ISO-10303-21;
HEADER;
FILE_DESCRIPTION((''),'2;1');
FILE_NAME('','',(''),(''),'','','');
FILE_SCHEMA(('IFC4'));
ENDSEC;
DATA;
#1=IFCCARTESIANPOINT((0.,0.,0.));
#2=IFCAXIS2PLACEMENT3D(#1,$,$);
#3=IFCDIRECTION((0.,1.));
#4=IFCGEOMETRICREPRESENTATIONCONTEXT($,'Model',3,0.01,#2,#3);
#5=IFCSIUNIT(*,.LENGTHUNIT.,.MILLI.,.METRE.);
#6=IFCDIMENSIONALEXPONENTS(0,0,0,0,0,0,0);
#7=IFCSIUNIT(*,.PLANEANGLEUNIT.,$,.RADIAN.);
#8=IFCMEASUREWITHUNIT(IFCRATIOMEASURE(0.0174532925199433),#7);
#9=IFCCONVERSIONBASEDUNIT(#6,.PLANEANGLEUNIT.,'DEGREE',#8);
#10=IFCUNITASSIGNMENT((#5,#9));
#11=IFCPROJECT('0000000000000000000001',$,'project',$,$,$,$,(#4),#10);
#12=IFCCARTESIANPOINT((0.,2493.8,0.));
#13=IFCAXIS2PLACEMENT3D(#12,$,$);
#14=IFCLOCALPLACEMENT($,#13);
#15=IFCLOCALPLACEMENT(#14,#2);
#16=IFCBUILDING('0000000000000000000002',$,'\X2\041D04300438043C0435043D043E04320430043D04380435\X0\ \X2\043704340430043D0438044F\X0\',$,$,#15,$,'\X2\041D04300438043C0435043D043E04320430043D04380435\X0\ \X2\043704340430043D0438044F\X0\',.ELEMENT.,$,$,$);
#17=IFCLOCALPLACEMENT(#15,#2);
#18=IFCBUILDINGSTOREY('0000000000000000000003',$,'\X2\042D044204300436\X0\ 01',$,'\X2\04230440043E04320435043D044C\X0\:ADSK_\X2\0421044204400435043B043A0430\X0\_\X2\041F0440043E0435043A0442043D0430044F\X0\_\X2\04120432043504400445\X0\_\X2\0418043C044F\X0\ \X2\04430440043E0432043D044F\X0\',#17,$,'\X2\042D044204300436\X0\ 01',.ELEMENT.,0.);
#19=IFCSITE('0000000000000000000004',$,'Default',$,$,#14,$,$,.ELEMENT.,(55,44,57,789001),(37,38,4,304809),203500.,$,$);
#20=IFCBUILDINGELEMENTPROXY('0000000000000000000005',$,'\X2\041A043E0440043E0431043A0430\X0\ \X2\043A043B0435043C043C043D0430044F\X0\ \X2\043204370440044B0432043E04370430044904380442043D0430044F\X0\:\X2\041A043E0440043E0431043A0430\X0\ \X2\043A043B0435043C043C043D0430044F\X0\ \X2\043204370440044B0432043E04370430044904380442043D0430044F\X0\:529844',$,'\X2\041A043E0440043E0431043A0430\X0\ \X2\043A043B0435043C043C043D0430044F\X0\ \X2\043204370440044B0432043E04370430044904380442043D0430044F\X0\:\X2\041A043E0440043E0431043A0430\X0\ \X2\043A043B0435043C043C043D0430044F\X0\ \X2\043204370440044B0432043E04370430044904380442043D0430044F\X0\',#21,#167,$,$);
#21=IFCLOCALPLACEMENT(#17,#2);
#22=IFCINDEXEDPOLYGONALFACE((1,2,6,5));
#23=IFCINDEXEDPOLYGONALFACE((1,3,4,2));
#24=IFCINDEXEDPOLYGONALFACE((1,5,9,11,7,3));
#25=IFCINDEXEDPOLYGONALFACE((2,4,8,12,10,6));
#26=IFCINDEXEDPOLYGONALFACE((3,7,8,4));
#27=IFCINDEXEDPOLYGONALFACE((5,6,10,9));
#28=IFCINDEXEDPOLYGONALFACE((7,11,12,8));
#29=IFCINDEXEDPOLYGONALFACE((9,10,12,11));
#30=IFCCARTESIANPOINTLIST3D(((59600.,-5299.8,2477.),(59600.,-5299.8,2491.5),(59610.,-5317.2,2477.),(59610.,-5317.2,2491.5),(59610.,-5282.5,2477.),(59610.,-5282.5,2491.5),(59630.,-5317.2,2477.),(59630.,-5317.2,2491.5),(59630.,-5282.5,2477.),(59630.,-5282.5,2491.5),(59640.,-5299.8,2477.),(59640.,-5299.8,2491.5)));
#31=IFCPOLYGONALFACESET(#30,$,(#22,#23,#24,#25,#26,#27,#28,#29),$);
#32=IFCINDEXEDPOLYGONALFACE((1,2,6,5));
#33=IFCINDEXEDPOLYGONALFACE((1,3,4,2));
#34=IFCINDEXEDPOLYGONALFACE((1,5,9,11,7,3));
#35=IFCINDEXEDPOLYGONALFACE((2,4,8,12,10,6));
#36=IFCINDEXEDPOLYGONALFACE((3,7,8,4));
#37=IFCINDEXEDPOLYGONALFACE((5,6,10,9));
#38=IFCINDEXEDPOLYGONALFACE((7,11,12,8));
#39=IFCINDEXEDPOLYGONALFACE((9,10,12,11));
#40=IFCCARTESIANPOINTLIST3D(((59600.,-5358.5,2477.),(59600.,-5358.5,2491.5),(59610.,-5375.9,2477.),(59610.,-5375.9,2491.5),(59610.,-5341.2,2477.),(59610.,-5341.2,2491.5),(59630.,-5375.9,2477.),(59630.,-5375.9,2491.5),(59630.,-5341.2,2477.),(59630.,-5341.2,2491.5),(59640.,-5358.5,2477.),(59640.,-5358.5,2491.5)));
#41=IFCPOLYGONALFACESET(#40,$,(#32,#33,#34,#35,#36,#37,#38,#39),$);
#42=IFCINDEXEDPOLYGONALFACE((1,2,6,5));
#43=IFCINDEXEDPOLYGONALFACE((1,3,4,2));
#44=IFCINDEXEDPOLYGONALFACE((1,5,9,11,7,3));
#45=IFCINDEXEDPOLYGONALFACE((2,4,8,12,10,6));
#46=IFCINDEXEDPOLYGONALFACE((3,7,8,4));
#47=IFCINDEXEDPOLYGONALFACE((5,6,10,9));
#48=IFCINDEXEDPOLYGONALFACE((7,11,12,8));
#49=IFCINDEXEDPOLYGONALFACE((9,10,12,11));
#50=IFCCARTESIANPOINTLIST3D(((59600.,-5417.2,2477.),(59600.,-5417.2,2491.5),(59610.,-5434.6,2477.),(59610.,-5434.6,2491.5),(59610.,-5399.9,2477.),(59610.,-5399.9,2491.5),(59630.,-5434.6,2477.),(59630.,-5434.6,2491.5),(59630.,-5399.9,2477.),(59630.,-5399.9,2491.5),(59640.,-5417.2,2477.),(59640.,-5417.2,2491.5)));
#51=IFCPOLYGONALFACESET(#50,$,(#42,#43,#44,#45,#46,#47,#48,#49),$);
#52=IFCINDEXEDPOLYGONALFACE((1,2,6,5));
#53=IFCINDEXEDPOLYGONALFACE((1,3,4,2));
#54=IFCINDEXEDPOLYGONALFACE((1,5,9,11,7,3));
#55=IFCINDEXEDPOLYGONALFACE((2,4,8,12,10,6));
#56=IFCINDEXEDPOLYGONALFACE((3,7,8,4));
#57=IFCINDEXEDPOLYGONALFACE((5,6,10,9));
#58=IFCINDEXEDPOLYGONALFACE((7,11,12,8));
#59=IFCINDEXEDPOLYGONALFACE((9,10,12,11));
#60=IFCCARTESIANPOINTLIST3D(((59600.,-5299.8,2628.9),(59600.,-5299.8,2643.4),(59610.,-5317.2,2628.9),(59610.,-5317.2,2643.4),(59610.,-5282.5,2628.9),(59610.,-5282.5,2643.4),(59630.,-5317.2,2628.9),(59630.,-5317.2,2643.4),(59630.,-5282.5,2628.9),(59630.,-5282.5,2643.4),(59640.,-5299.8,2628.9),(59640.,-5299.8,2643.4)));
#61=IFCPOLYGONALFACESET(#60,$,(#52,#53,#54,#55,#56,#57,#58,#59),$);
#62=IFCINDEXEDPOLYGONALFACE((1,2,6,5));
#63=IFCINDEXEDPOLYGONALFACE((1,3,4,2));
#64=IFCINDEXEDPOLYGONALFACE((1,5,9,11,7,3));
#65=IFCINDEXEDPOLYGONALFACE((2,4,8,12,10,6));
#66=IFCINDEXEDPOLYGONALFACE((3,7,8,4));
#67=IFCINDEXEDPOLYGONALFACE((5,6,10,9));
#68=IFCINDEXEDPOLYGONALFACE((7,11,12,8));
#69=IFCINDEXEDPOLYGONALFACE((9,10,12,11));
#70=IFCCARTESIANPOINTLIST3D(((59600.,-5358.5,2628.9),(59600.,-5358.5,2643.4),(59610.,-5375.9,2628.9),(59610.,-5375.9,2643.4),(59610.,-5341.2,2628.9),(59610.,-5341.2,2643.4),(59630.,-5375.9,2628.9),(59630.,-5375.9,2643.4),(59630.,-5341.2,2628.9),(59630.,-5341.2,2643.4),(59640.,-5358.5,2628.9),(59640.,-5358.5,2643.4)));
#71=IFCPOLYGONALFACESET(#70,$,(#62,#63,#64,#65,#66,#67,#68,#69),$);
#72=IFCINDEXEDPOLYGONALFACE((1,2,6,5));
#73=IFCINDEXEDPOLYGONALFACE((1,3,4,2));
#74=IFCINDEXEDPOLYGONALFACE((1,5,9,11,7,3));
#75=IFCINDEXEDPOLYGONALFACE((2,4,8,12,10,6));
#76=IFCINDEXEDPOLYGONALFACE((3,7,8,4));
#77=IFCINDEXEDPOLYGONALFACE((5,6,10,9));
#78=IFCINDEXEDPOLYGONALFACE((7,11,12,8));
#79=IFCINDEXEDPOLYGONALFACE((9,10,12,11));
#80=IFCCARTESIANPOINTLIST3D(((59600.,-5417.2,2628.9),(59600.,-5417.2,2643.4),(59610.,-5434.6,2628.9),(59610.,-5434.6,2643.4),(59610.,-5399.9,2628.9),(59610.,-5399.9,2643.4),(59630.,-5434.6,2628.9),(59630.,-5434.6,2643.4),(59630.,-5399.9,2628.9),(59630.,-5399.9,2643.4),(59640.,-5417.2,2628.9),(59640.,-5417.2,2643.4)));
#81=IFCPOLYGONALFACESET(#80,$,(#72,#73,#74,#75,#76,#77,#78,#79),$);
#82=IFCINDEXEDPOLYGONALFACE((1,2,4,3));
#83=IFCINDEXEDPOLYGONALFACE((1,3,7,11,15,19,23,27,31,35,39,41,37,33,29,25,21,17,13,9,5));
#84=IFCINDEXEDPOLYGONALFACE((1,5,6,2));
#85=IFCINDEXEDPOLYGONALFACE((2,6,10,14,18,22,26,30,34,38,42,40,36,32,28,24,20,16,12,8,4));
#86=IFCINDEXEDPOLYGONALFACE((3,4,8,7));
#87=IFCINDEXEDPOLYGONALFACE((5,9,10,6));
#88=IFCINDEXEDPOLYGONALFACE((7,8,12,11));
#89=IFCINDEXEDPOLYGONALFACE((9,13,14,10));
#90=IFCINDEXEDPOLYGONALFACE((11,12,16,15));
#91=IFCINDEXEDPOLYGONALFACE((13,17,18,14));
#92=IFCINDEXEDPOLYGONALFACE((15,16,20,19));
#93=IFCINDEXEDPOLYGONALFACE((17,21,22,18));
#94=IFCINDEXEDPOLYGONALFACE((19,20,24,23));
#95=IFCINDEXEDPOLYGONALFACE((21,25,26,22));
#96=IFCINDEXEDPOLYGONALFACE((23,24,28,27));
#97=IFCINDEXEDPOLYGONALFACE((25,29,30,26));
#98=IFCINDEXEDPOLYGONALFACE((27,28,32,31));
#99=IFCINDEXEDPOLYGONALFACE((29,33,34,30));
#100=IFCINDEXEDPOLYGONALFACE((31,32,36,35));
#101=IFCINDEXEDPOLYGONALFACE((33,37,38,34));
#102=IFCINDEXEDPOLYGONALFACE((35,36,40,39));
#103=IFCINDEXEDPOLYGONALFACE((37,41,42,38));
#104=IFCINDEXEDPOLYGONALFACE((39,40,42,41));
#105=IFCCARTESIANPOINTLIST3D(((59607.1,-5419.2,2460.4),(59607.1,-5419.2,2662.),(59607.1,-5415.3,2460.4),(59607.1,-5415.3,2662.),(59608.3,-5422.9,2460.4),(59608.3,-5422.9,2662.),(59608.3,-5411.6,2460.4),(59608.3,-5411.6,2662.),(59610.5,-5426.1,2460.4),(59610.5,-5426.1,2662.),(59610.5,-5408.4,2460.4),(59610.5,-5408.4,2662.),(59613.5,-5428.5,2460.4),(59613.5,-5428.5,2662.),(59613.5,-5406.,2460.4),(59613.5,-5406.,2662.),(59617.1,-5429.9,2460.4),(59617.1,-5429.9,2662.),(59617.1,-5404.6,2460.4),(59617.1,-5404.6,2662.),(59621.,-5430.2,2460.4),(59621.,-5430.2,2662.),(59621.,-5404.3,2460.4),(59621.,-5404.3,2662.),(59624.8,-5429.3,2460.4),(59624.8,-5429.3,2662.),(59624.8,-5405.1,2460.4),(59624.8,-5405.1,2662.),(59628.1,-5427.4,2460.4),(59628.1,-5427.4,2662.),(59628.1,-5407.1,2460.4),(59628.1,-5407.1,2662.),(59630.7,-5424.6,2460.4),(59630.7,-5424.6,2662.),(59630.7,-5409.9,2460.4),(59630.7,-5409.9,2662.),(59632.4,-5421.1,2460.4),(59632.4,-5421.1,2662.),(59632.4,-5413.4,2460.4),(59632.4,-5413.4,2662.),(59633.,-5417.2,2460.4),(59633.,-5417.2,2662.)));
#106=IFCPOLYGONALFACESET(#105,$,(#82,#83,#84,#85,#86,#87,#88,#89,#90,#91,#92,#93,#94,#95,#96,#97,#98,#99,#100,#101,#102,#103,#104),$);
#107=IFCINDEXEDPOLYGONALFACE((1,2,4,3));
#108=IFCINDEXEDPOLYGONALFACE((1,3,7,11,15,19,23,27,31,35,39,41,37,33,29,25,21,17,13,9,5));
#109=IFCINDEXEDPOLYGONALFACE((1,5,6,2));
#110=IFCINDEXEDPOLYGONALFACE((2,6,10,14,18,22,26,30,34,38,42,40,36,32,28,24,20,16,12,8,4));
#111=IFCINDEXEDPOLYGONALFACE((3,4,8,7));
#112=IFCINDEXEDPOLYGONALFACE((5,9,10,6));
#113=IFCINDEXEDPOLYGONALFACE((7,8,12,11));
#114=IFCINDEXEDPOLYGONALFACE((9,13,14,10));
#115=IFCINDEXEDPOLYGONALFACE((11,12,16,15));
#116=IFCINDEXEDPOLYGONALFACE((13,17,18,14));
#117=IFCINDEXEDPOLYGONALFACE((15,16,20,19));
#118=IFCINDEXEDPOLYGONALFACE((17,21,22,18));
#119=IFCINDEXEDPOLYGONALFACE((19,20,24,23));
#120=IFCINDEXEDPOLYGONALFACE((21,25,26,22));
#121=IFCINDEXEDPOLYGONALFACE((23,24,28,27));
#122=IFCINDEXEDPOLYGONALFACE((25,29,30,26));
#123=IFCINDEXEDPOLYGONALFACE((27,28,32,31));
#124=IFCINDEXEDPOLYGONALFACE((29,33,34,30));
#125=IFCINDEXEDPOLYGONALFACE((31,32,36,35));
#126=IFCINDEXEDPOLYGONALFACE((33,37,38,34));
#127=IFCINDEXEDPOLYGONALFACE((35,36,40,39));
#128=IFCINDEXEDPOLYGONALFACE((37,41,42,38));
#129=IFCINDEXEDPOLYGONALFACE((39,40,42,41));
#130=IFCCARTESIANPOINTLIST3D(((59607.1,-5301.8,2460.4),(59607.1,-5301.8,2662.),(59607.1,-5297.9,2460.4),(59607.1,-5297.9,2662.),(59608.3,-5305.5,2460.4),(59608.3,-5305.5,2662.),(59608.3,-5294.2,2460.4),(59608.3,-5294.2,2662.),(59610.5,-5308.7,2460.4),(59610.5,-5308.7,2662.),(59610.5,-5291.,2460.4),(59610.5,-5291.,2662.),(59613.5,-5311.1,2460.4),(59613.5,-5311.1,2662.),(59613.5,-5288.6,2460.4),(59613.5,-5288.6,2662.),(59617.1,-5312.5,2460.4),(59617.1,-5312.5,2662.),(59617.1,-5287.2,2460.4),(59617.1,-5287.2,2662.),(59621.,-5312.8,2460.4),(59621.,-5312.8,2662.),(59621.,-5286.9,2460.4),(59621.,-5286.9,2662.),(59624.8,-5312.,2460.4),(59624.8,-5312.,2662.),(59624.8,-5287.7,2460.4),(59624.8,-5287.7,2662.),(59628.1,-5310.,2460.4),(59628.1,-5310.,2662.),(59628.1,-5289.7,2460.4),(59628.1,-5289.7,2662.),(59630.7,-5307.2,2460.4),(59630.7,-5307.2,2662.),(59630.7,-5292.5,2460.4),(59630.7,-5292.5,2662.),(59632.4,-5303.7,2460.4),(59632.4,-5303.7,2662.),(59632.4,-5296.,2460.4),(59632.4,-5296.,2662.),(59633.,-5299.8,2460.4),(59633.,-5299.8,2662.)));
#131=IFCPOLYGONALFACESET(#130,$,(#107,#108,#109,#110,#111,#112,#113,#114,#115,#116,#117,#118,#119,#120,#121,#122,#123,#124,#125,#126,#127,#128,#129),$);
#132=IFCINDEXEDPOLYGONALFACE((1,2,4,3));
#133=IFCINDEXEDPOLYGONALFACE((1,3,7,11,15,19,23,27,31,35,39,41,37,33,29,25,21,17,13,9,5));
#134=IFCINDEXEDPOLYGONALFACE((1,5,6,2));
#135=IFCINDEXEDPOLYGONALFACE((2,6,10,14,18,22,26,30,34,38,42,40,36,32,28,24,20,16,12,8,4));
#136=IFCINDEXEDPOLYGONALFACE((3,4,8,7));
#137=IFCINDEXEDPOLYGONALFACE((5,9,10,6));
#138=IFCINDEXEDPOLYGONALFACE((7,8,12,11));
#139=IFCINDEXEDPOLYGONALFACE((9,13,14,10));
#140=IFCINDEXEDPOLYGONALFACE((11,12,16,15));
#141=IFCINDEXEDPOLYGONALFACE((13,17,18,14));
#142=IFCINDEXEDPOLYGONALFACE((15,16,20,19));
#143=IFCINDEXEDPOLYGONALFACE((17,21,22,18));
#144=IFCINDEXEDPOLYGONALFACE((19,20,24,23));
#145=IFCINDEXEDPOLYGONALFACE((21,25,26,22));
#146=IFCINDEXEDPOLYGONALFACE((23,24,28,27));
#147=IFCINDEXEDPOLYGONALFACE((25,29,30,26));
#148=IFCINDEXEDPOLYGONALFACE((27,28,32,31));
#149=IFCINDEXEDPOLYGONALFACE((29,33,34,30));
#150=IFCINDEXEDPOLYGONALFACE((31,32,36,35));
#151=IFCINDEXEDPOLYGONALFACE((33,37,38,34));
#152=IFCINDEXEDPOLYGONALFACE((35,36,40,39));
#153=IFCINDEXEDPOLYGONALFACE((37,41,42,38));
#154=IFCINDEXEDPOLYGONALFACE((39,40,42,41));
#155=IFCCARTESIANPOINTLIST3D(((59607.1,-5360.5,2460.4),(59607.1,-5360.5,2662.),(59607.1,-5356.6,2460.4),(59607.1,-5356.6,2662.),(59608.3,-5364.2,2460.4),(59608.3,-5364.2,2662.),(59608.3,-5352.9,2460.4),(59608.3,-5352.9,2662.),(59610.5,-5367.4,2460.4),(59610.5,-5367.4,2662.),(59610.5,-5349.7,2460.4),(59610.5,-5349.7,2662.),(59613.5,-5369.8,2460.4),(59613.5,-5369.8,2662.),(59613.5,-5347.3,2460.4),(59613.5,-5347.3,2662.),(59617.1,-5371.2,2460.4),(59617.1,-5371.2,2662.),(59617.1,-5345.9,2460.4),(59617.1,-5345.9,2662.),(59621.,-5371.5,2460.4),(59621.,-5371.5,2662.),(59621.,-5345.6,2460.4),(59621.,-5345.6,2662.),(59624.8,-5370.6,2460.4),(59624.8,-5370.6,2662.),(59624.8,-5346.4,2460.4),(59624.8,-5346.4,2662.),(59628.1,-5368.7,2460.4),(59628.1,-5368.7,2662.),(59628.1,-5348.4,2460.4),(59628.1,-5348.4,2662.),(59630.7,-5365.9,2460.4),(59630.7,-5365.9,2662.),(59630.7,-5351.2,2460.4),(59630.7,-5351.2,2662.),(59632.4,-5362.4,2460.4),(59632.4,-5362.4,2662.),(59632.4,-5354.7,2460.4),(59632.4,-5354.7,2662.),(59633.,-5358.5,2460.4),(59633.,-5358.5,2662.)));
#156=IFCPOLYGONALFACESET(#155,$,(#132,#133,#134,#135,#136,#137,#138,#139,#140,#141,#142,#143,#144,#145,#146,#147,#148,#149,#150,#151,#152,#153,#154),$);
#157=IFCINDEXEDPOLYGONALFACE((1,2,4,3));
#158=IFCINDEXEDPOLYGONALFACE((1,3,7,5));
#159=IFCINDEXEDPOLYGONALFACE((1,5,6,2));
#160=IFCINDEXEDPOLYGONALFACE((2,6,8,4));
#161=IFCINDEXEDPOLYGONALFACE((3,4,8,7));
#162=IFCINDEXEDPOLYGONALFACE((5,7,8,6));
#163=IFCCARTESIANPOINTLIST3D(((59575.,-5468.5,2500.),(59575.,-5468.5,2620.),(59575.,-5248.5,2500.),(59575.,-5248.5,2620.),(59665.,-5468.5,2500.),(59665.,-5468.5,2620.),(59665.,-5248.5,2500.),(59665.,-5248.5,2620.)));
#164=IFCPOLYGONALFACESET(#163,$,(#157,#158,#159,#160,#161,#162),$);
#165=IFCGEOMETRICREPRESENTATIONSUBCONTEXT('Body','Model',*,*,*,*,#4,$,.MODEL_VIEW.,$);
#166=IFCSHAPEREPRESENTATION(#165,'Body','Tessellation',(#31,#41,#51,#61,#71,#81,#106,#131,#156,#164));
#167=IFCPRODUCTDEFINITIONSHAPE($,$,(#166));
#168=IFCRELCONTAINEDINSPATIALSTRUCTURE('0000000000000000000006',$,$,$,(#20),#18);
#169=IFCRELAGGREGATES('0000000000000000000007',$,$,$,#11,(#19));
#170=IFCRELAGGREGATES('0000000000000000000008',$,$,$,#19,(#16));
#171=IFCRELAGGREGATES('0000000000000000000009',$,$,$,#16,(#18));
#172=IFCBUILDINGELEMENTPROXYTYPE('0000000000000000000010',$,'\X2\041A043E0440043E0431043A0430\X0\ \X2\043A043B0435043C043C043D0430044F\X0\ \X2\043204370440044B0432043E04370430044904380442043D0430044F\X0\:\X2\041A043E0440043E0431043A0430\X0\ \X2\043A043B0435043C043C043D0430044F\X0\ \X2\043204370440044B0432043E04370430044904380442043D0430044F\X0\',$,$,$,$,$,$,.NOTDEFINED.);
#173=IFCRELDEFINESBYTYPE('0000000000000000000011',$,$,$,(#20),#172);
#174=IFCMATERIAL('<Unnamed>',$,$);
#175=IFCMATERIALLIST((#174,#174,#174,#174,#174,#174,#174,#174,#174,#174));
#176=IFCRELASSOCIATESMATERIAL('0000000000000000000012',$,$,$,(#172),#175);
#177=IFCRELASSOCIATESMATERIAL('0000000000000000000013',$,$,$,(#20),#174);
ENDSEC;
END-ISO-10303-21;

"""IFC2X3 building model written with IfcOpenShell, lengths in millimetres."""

from ifc_helpers import new_model, entity, si_unit, converted_unit, direction, frame, frame_2d, origin, place, context, subcontext, project, spatial, polyline, rectangle, circle, outline, extrude, source, transform, mapped, material, material_list, type_object, type_shapes, element, save


model = new_model("IFC2X3")

# Units and contexts
model_context = context("Model", 3, precision=0.01, world=origin(), true_north=direction((0.0, 1.0)))
body_context = subcontext(model_context, "Body", "Model", "MODEL_VIEW")
ifc_project = project(units=[si_unit("LENGTHUNIT", "METRE", prefix="MILLI"), converted_unit("PLANEANGLEUNIT", "DEGREE", entity("IfcRatioMeasure", 0.0174532925199433), si_unit("PLANEANGLEUNIT", "RADIAN"), dimensions=[0, 0, 0, 0, 0, 0, 0])], contexts=[model_context])

# Site, building, storey
site_placement = place(None, frame((0.0, 2493.8, 0.0)))
site = spatial("IfcSite", under=ifc_project, at=site_placement, Name="Default", CompositionType="ELEMENT", RefLatitude=(55, 44, 57, 789001), RefLongitude=(37, 38, 4, 304809), RefElevation=203500.0)
building_placement = place(site_placement, origin())
building = spatial("IfcBuilding", under=site, at=building_placement, Name="Наименование здания", LongName="Наименование здания", CompositionType="ELEMENT")
storey_placement = place(building_placement, origin())
storey = spatial("IfcBuildingStorey", under=building, at=storey_placement, Name="Этаж 01", ObjectType="Уровень:ADSK_Стрелка_Проектная_Вверх_Имя уровня", LongName="Этаж 01", CompositionType="ELEMENT", Elevation=0.0)

# Building element proxy
ifc_material_1 = material(Name="<Unnamed>")
ifc_material_list_1 = material_list([ifc_material_1, ifc_material_1, ifc_material_1, ifc_material_1, ifc_material_1, ifc_material_1, ifc_material_1, ifc_material_1, ifc_material_1, ifc_material_1])
building_element_proxy_type_1 = type_object("IfcBuildingElementProxyType", Name="Коробка клеммная взрывозащитная:Коробка клеммная взрывозащитная", PredefinedType="NOTDEFINED", material=ifc_material_list_1)
shared_shape_1 = source(origin(), body_context, "Body", "SweptSolid", [
    extrude(outline(polyline([(-10.0, -17.3), (10.0, -17.3), (20.0, 0.0), (10.0, 17.3), (-10.0, 17.3), (-20.0, 0.0), (-10.0, -17.3)])), frame((0.0, 58.7, -23.0), z_axis=(0.0, 0.0, 1.0), x_axis=(-1.0, 0.0, 0.0)), (0.0, 0.0, 1.0), 14.4),
    extrude(outline(polyline([(-10.0, -17.3), (10.0, -17.3), (20.0, 0.0), (10.0, 17.3), (-10.0, 17.3), (-20.0, 0.0), (-10.0, -17.3)])), frame((0.0, 0.0, -23.0), z_axis=(0.0, 0.0, 1.0), x_axis=(-1.0, 0.0, 0.0)), (0.0, 0.0, 1.0), 14.4),
    extrude(outline(polyline([(-10.0, -17.3), (10.0, -17.3), (20.0, 0.0), (10.0, 17.3), (-10.0, 17.3), (-20.0, 0.0), (-10.0, -17.3)])), frame((0.0, -58.7, -23.0), z_axis=(0.0, 0.0, 1.0), x_axis=(-1.0, 0.0, 0.0)), (0.0, 0.0, 1.0), 14.4),
    extrude(outline(polyline([(-10.0, -17.3), (10.0, -17.3), (20.0, 0.0), (10.0, 17.3), (-10.0, 17.3), (-20.0, 0.0), (-10.0, -17.3)])), frame((0.0, 58.7, 128.9), z_axis=(0.0, 0.0, 1.0), x_axis=(-1.0, 0.0, 0.0)), (0.0, 0.0, 1.0), 14.4),
    extrude(outline(polyline([(-10.0, -17.3), (10.0, -17.3), (20.0, 0.0), (10.0, 17.3), (-10.0, 17.3), (-20.0, 0.0), (-10.0, -17.3)])), frame((0.0, 0.0, 128.9), z_axis=(0.0, 0.0, 1.0), x_axis=(-1.0, 0.0, 0.0)), (0.0, 0.0, 1.0), 14.4),
    extrude(outline(polyline([(-10.0, -17.3), (10.0, -17.3), (20.0, 0.0), (10.0, 17.3), (-10.0, 17.3), (-20.0, 0.0), (-10.0, -17.3)])), frame((0.0, -58.7, 128.9), z_axis=(0.0, 0.0, 1.0), x_axis=(-1.0, 0.0, 0.0)), (0.0, 0.0, 1.0), 14.4),
    extrude(circle(Radius=13.0, at=frame_2d((0.0, 0.0), x_axis=(1.0, 0.0))), frame((0.0, -58.7, -39.6)), (0.0, 0.0, 1.0), 201.6),
    extrude(circle(Radius=13.0, at=frame_2d((0.0, 0.0), x_axis=(1.0, 0.0))), frame((0.0, 58.7, -39.6)), (0.0, 0.0, 1.0), 201.6),
    extrude(circle(Radius=13.0, at=frame_2d((0.0, 0.0), x_axis=(1.0, 0.0))), frame((0.0, 0.0, -39.6)), (0.0, 0.0, 1.0), 201.6),
    extrude(rectangle(XDim=220.0, YDim=90.0, at=frame_2d((0.0, 0.0), x_axis=(1.0, 0.0))), frame((0.0, 0.0, 0.0), z_axis=(0.0, 0.0, 1.0), x_axis=(0.0, -1.0, 0.0)), (0.0, 0.0, 1.0), 120.0),
])
type_shapes(building_element_proxy_type_1, [shared_shape_1])
for number, where, name in (
    (1, (59620.0, -5358.5, 2500.0), "Коробка клеммная взрывозащитная:Коробка клеммная взрывозащитная:529844"),
):
    element("IfcBuildingElementProxy", number, at=place(storey_placement, frame(where)), inside=storey, type_object=building_element_proxy_type_1, material=ifc_material_1, Name=name, ObjectType="Коробка клеммная взрывозащитная:Коробка клеммная взрывозащитная", context=body_context, shape_type="MappedRepresentation", body=[
        mapped(shared_shape_1, transform((0.0, 0.0, 0.0), scale=1.0)),
    ])

save(model, "model.ifc")
